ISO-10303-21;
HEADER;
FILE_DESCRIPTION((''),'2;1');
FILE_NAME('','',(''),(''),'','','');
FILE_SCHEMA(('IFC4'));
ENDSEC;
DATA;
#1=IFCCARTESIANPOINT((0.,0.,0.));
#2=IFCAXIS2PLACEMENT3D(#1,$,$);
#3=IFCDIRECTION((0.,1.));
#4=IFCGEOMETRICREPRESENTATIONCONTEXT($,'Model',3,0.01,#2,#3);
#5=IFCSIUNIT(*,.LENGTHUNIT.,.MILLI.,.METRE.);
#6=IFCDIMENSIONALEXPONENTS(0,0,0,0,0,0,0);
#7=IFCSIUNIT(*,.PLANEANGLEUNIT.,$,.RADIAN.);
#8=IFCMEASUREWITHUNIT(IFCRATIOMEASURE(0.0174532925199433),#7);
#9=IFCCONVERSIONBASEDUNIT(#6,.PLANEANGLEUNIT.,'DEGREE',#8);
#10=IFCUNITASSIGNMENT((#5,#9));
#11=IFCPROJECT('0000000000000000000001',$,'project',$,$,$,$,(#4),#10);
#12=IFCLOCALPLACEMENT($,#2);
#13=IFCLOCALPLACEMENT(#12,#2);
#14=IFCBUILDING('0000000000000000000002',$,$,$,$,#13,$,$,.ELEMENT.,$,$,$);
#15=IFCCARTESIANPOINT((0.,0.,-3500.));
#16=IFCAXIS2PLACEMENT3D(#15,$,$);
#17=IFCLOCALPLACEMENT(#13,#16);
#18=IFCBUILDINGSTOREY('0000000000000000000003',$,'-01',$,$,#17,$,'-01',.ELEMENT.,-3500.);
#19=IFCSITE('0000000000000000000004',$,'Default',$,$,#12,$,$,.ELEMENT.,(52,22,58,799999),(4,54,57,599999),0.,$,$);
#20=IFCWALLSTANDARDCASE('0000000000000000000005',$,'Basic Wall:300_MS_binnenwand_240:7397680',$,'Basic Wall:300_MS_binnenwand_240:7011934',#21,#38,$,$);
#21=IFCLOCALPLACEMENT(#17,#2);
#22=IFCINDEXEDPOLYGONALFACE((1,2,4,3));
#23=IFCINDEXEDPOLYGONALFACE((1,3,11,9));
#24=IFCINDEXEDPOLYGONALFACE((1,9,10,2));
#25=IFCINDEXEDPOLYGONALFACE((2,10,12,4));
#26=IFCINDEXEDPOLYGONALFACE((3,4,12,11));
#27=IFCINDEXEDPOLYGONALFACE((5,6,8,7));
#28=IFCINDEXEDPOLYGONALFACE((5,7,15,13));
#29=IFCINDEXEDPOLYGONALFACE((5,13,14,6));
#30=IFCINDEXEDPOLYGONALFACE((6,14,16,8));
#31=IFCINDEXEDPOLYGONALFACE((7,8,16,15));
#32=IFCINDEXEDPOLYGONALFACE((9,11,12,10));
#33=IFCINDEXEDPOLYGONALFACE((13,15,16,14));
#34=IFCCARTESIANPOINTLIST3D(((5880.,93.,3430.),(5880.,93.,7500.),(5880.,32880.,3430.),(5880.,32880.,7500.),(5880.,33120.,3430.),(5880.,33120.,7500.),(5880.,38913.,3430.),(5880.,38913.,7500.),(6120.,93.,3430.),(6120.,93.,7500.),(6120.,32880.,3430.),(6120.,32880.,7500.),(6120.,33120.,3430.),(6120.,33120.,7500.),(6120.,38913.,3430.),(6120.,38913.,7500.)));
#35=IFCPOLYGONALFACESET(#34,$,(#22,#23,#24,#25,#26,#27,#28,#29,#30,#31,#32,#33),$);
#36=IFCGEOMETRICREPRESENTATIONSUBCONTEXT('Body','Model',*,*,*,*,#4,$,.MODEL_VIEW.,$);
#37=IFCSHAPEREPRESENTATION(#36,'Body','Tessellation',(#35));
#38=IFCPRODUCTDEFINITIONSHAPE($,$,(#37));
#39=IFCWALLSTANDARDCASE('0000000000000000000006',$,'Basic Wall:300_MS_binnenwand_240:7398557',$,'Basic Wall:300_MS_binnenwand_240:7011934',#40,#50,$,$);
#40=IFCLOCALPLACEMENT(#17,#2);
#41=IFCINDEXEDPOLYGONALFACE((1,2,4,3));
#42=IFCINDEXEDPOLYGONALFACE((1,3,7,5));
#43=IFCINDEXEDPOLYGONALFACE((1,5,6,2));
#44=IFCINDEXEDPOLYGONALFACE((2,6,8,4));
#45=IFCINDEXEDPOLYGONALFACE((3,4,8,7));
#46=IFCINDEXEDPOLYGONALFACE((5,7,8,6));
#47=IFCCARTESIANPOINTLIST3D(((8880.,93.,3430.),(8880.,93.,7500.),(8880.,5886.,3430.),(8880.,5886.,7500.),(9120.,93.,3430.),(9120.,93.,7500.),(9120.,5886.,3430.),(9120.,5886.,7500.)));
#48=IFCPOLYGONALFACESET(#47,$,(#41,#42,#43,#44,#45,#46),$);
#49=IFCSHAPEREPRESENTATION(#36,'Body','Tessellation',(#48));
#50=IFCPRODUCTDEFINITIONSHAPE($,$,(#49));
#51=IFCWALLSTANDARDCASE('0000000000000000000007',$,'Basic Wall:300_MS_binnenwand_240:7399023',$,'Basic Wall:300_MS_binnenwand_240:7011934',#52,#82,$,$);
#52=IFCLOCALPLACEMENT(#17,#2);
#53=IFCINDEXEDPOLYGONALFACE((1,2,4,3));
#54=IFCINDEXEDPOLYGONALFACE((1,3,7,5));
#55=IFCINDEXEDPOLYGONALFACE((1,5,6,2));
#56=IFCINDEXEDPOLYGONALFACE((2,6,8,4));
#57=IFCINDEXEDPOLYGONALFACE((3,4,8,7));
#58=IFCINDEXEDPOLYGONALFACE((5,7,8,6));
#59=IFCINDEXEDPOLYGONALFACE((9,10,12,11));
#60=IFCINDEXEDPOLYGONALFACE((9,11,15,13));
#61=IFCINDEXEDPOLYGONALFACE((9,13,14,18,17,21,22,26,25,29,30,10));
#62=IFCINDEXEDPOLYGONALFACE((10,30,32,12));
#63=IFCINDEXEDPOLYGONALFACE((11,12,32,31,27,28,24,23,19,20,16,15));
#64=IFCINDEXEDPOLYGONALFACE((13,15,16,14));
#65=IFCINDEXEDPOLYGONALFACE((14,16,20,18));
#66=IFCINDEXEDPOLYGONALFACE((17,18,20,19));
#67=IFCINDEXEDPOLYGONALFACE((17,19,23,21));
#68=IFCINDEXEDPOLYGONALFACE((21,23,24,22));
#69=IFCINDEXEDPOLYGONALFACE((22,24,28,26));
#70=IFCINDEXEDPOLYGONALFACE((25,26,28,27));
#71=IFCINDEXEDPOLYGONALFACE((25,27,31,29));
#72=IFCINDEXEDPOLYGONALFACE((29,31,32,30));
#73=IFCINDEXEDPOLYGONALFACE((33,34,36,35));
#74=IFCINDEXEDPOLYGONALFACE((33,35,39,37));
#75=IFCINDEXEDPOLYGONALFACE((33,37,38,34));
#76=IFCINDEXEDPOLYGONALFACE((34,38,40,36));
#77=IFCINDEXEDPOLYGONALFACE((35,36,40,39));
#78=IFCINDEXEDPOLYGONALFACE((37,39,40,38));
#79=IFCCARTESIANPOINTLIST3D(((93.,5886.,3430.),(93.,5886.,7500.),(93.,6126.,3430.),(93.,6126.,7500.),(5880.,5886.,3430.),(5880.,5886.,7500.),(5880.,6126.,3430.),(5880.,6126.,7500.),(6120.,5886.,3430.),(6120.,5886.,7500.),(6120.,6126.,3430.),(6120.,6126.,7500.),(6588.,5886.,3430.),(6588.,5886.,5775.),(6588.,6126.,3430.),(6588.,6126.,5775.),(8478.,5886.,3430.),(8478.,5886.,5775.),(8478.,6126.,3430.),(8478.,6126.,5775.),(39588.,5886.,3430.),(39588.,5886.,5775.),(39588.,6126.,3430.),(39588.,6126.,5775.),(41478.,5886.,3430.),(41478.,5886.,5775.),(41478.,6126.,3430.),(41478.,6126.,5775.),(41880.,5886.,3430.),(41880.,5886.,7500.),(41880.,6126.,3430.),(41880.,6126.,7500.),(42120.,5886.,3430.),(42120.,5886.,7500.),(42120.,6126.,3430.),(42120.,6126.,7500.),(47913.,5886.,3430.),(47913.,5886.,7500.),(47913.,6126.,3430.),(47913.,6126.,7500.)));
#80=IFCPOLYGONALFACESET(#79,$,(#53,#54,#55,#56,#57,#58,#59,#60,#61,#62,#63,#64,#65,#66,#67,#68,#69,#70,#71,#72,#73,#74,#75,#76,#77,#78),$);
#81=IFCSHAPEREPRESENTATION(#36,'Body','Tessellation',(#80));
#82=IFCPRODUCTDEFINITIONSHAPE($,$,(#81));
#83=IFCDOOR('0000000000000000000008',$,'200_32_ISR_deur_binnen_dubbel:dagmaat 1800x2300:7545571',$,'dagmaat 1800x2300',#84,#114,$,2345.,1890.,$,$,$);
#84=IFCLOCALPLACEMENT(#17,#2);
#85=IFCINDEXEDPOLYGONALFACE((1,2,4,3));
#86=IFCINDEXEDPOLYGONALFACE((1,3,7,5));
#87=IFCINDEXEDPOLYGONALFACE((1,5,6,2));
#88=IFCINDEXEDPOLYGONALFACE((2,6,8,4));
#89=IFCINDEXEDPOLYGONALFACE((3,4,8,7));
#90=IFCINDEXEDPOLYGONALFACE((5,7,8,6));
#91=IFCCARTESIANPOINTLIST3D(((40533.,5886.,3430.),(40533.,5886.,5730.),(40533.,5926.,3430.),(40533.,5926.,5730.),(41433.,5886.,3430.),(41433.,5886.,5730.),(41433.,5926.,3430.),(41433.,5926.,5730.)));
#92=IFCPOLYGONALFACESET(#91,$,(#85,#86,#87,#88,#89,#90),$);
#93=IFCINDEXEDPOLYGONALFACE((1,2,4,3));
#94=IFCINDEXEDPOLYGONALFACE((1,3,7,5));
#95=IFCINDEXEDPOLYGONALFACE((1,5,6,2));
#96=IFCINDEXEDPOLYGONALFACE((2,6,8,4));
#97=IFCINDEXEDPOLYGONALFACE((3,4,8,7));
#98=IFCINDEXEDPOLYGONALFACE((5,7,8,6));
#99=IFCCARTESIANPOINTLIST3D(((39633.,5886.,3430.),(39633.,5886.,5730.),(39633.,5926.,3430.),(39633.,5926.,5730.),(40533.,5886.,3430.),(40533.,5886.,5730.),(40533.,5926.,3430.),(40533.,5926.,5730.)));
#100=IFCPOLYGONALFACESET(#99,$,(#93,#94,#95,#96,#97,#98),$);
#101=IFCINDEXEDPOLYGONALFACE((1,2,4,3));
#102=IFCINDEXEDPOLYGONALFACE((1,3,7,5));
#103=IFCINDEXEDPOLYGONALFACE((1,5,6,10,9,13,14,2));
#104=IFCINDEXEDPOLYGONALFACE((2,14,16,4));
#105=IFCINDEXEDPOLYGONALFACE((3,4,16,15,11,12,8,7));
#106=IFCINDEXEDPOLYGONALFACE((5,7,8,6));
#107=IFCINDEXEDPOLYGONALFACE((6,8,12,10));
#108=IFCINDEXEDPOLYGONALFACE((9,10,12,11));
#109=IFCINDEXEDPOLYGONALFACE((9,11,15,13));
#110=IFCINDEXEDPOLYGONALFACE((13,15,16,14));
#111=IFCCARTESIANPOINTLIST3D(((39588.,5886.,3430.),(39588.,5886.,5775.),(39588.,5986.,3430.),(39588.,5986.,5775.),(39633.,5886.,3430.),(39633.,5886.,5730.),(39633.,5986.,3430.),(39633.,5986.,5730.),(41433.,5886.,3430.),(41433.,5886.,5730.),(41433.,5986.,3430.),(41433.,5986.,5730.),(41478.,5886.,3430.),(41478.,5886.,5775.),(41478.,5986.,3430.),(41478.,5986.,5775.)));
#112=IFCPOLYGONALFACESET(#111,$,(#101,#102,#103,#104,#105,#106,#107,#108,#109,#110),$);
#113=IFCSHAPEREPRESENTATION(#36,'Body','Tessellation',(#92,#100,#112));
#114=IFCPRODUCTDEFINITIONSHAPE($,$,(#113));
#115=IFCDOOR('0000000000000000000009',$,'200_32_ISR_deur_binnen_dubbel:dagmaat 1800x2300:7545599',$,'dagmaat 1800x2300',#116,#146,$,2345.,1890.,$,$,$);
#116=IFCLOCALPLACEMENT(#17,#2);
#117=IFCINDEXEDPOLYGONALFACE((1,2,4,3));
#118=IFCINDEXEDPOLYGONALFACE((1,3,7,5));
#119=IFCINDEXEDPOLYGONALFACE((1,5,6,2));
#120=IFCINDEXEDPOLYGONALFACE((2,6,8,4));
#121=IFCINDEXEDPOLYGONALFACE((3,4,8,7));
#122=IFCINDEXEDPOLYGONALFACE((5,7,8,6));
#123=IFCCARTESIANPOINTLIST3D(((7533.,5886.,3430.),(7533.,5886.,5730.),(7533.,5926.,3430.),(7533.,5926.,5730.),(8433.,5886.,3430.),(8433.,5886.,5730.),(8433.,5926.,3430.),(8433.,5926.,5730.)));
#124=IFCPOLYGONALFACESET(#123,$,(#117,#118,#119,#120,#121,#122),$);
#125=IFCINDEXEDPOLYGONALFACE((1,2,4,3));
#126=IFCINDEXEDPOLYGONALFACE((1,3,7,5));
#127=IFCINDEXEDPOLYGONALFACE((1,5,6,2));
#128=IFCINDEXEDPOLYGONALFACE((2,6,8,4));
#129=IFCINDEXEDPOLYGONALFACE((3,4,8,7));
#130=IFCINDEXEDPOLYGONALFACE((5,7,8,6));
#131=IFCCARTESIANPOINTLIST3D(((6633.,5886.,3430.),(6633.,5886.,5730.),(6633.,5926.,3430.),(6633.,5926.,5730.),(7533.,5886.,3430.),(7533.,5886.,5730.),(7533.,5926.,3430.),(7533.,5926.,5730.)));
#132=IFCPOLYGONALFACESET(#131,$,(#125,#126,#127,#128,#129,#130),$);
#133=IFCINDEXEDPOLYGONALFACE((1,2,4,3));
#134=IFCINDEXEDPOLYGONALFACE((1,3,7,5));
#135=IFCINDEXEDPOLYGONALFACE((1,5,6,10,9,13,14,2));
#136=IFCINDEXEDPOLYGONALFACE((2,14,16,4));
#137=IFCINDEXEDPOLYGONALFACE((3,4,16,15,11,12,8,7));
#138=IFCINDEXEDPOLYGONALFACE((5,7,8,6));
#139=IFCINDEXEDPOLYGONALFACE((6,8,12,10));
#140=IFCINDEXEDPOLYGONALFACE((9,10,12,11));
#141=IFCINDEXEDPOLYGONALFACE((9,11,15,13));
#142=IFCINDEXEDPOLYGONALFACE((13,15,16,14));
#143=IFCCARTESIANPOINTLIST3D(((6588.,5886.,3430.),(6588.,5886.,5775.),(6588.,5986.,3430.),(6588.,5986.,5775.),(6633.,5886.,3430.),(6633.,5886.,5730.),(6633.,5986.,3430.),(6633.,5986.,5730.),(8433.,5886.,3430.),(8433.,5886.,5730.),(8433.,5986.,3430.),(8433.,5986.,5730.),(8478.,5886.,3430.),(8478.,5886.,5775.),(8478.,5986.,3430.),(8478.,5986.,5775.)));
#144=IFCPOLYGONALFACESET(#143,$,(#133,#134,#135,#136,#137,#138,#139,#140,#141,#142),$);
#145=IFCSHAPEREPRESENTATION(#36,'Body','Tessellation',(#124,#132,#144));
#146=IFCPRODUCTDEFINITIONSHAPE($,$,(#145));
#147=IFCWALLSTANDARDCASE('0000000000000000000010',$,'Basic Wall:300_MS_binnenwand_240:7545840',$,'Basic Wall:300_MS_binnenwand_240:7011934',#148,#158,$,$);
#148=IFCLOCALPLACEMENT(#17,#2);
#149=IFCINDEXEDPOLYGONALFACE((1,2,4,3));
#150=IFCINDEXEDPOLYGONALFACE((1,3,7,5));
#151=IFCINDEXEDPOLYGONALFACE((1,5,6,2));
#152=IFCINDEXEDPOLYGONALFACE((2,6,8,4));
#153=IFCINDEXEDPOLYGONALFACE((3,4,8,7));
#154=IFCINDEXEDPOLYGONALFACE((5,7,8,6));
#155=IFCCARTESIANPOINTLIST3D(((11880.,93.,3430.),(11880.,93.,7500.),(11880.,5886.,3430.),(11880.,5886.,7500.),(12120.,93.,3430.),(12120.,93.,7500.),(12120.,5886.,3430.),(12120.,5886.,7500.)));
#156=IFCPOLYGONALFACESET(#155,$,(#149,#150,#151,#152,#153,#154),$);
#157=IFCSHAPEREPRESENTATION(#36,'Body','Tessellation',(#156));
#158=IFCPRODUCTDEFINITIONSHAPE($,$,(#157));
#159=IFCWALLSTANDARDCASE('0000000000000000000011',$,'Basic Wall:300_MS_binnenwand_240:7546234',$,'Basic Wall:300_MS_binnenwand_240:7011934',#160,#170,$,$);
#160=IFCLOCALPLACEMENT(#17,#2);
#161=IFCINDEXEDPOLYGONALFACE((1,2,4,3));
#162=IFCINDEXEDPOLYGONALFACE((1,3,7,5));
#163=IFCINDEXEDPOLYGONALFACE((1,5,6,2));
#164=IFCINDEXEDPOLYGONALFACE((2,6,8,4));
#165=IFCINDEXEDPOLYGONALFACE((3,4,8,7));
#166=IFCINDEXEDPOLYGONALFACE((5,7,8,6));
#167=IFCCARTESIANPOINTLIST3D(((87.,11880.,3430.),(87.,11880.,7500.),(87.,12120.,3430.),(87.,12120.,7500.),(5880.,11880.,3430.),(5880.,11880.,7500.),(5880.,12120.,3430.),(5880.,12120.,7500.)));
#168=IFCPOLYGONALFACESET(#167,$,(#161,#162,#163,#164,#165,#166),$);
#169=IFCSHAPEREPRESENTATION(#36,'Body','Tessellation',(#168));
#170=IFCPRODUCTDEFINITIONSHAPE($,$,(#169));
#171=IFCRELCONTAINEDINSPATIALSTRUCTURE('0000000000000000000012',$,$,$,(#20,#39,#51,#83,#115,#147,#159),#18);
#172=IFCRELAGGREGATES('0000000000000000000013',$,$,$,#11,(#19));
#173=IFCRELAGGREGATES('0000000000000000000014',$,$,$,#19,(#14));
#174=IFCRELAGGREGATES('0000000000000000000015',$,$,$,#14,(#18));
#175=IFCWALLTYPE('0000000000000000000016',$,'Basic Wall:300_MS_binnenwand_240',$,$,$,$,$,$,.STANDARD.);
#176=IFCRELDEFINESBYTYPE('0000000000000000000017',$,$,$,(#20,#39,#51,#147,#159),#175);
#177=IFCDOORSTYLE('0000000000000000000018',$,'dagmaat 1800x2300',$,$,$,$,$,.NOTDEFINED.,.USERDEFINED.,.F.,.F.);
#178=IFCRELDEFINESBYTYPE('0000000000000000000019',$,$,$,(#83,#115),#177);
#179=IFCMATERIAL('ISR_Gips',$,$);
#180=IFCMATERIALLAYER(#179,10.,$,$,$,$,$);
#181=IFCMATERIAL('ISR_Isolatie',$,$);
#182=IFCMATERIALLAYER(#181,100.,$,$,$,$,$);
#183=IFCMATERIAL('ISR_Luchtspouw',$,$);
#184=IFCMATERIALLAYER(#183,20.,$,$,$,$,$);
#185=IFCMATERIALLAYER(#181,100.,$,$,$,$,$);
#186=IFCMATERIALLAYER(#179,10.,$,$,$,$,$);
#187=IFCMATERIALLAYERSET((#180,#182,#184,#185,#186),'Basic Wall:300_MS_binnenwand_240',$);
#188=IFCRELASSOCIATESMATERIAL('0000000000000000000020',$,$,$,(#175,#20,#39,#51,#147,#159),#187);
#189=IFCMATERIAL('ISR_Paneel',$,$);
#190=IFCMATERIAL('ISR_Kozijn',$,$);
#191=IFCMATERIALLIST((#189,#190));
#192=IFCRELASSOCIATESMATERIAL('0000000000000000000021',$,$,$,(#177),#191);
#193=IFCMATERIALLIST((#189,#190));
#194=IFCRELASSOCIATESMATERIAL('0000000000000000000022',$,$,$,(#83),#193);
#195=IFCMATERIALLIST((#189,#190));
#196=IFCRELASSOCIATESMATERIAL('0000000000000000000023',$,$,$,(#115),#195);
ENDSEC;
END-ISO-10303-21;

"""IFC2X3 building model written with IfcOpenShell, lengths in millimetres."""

from ifc_helpers import new_model, entity, si_unit, converted_unit, direction, frame, frame_2d, origin, origin_2d_with_axis, place, context, subcontext, project, spatial, polyline, rectangle, outline, extrude, source, transform, mapped, material, material_list, layer, layer_set, layer_usage, type_object, type_shapes, element, fill, save


model = new_model("IFC2X3")

# Units and contexts
model_context = context("Model", 3, precision=0.01, world=origin(), true_north=direction((0.0, 1.0)))
body_context = subcontext(model_context, "Body", "Model", "MODEL_VIEW")
ifc_project = project(units=[si_unit("LENGTHUNIT", "METRE", prefix="MILLI"), converted_unit("PLANEANGLEUNIT", "DEGREE", entity("IfcRatioMeasure", 0.0174532925199433), si_unit("PLANEANGLEUNIT", "RADIAN"), dimensions=[0, 0, 0, 0, 0, 0, 0])], contexts=[model_context])

# Site, building, storey
site_placement = place(None, origin())
site = spatial("IfcSite", under=ifc_project, at=site_placement, Name="Default", CompositionType="ELEMENT", RefLatitude=(52, 22, 58, 799999), RefLongitude=(4, 54, 57, 599999), RefElevation=0.0)
building_placement = place(site_placement, origin())
building = spatial("IfcBuilding", under=site, at=building_placement, CompositionType="ELEMENT")
storey_placement = place(building_placement, frame((0.0, 0.0, -3500.0)))
storey = spatial("IfcBuildingStorey", under=building, at=storey_placement, Name="-01", LongName="-01", CompositionType="ELEMENT", Elevation=-3500.0)

# Shared definitions
ifc_material_1 = material(Name="ISR_Kozijn")

# Wall, opening
ifc_material_2 = material(Name="ISR_Gips")
ifc_layer_1 = layer(ifc_material_2, 10.0)
ifc_material_3 = material(Name="ISR_Isolatie")
ifc_layer_2 = layer(ifc_material_3, 100.0)
ifc_material_4 = material(Name="ISR_Luchtspouw")
ifc_layer_3 = layer(ifc_material_4, 20.0)
ifc_layer_4 = layer(ifc_material_3, 100.0)
ifc_layer_5 = layer(ifc_material_2, 10.0)
ifc_layer_set_1 = layer_set([ifc_layer_1, ifc_layer_2, ifc_layer_3, ifc_layer_4, ifc_layer_5], Name="Basic Wall:300_MS_binnenwand_240")
ifc_layer_usage_1 = layer_usage(ifc_layer_set_1, "AXIS2", "NEGATIVE", 120.0)
wall_type_1 = type_object("IfcWallType", Name="Basic Wall:300_MS_binnenwand_240", PredefinedType="STANDARD", material=ifc_layer_set_1)
wall_1_placement = place(storey_placement, frame((6000.0, 93.0, 3430.0), z_axis=(0.0, 0.0, 1.0), x_axis=(0.0, 1.0, 0.0)))
wall_1 = element("IfcWallStandardCase", 1, at=wall_1_placement, inside=storey, type_object=wall_type_1, material=ifc_layer_usage_1, Name="Basic Wall:300_MS_binnenwand_240:7397680", ObjectType="Basic Wall:300_MS_binnenwand_240:7011934", context=body_context, shape_type="SweptSolid", body=[
    extrude(rectangle(XDim=38820.0, YDim=240.0, at=frame_2d((19410.0, 0.0), x_axis=(-1.0, 0.0))), origin(), (0.0, 0.0, 1.0), 4070.0),
])
opening_1_placement = place(storey_placement, frame((6000.0, 93.0, 3430.0), z_axis=(0.0, 0.0, 1.0), x_axis=(0.0, 1.0, 0.0)))
element("IfcOpeningElement", 2, at=opening_1_placement, cuts=wall_1, ObjectType="Opening", context=body_context, shape_type="SweptSolid", body=[
    extrude(rectangle(XDim=4070.0, YDim=240.0, at=frame_2d((0.0, 0.0), x_axis=(1.0, 0.0))), frame((32787.0, 0.0, 2035.0), z_axis=(1.0, 0.0, 0.0), x_axis=(0.0, 0.0, -1.0)), (0.0, 0.0, 1.0), 240.0),
])

# Wall
ifc_layer_usage_2 = layer_usage(ifc_layer_set_1, "AXIS2", "POSITIVE", -120.0)
wall_2_placement = place(storey_placement, frame((9000.0, 5886.0, 3430.0), z_axis=(0.0, 0.0, 1.0), x_axis=(0.0, -1.0, 0.0)))
element("IfcWallStandardCase", 3, at=wall_2_placement, inside=storey, type_object=wall_type_1, material=ifc_layer_usage_2, Name="Basic Wall:300_MS_binnenwand_240:7398557", ObjectType="Basic Wall:300_MS_binnenwand_240:7011934", context=body_context, shape_type="SweptSolid", body=[
    extrude(rectangle(XDim=5793.0, YDim=240.0, at=frame_2d((2896.5, 0.0), x_axis=(-1.0, 0.0))), origin(), (0.0, 0.0, 1.0), 4070.0),
])

# Wall, openings, doors
ifc_layer_usage_3 = layer_usage(ifc_layer_set_1, "AXIS2", "POSITIVE", -120.0)
wall_3_placement = place(storey_placement, frame((93.0, 6006.0, 3430.0)))
wall_3 = element("IfcWallStandardCase", 4, at=wall_3_placement, inside=storey, type_object=wall_type_1, material=ifc_layer_usage_3, Name="Basic Wall:300_MS_binnenwand_240:7399023", ObjectType="Basic Wall:300_MS_binnenwand_240:7011934", context=body_context, shape_type="SweptSolid", body=[
    extrude(rectangle(XDim=47820.0, YDim=240.0, at=frame_2d((23910.0, 0.0), x_axis=(-1.0, 0.0))), origin(), (0.0, 0.0, 1.0), 4070.0),
])
opening_2_placement = place(storey_placement, frame((93.0, 6006.0, 3430.0)))
element("IfcOpeningElement", 5, at=opening_2_placement, cuts=wall_3, ObjectType="Opening", context=body_context, shape_type="SweptSolid", body=[
    extrude(rectangle(XDim=4070.0, YDim=240.0, at=origin_2d_with_axis()), frame((41787.0, 0.0, 2035.0), z_axis=(1.0, 0.0, 0.0), x_axis=(0.0, 0.0, -1.0)), (0.0, 0.0, 1.0), 240.0),
])
opening_3_placement = place(storey_placement, frame((93.0, 6006.0, 3430.0)))
element("IfcOpeningElement", 6, at=opening_3_placement, cuts=wall_3, ObjectType="Opening", context=body_context, shape_type="SweptSolid", body=[
    extrude(rectangle(XDim=4070.0, YDim=240.0, at=frame_2d((0.0, 0.0), x_axis=(1.0, 0.0))), frame((5787.0, 0.0, 2035.0), z_axis=(1.0, 0.0, 0.0), x_axis=(0.0, 0.0, -1.0)), (0.0, 0.0, 1.0), 240.0),
])
opening_4_placement = place(wall_3_placement, frame((41385.0, 120.0, 0.0)))
opening_4 = element("IfcOpeningElement", 7, at=opening_4_placement, cuts=wall_3, ObjectType="Opening", context=body_context, shape_type="SweptSolid", body=[
    extrude(rectangle(XDim=2345.0, YDim=1890.0, at=frame_2d((1172.5, 945.0), x_axis=(-1.0, 0.0))), frame((0.0, 0.0, 0.0), z_axis=(0.0, -1.0, 0.0), x_axis=(0.0, 0.0, 1.0)), (0.0, 0.0, 1.0), 240.0),
])
opening_5_placement = place(wall_3_placement, frame((8385.0, 120.0, 0.0)))
opening_5 = element("IfcOpeningElement", 8, at=opening_5_placement, cuts=wall_3, ObjectType="Opening", context=body_context, shape_type="SweptSolid", body=[
    extrude(rectangle(XDim=2345.0, YDim=1890.0, at=frame_2d((1172.5, 945.0), x_axis=(-1.0, 0.0))), frame((0.0, 0.0, 0.0), z_axis=(0.0, -1.0, 0.0), x_axis=(0.0, 0.0, 1.0)), (0.0, 0.0, 1.0), 240.0),
])
ifc_material_5 = material(Name="ISR_Paneel")
ifc_material_list_1 = material_list([ifc_material_5, ifc_material_1])
ifc_material_list_2 = material_list([ifc_material_5, ifc_material_1])
door_style = type_object("IfcDoorStyle", Name="dagmaat 1800x2300", ConstructionType="USERDEFINED", OperationType="NOTDEFINED", ParameterTakesPrecedence=False, Sizeable=False, material=ifc_material_list_2)
shared_shape_1 = source(origin(), body_context, "Body", "SweptSolid", [
    extrude(rectangle(XDim=40.0, YDim=900.0, at=origin_2d_with_axis()), frame((495.0, 220.0, 0.0), z_axis=(0.0, 0.0, 1.0), x_axis=(0.0, -1.0, 0.0)), (0.0, 0.0, 1.0), 2300.0),
    extrude(rectangle(XDim=40.0, YDim=900.0, at=frame_2d((0.0, 0.0), x_axis=(1.0, 0.0))), frame((1395.0, 220.0, 0.0), z_axis=(0.0, 0.0, 1.0), x_axis=(0.0, 1.0, 0.0)), (0.0, 0.0, 1.0), 2300.0),
    extrude(outline(polyline([(-1161.2, -900.0), (-1161.2, -945.0), (1183.7, -945.0), (1183.7, 945.0), (-1161.2, 945.0), (-1161.2, 900.0), (1138.8, 900.0), (1138.8, -900.0), (-1161.2, -900.0)])), frame((945.0, 240.0, 1161.2), z_axis=(0.0, 1.0, 0.0), x_axis=(0.0, 0.0, 1.0)), (0.0, 0.0, -1.0), 100.0),
])
type_shapes(door_style, [shared_shape_1])
door_1_placement = place(opening_4_placement, frame((0.0, 0.0, 0.0), z_axis=(0.0, 0.0, 1.0), x_axis=(-1.0, 0.0, 0.0)))
door_1 = element("IfcDoor", 9, at=door_1_placement, inside=storey, type_object=door_style, material=ifc_material_list_1, Name="200_32_ISR_deur_binnen_dubbel:dagmaat 1800x2300:7545571", ObjectType="dagmaat 1800x2300", OverallHeight=2345.0, OverallWidth=1890.0, context=body_context, shape_type="MappedRepresentation", body=[
    mapped(shared_shape_1, transform((0.0, 0.0, 0.0), scale=1.0)),
])
fill(opening_4, door_1)
ifc_material_list_3 = material_list([ifc_material_5, ifc_material_1])
door_2_placement = place(opening_5_placement, frame((0.0, 0.0, 0.0), z_axis=(0.0, 0.0, 1.0), x_axis=(-1.0, 0.0, 0.0)))
door_2 = element("IfcDoor", 10, at=door_2_placement, inside=storey, type_object=door_style, material=ifc_material_list_3, Name="200_32_ISR_deur_binnen_dubbel:dagmaat 1800x2300:7545599", ObjectType="dagmaat 1800x2300", OverallHeight=2345.0, OverallWidth=1890.0, context=body_context, shape_type="MappedRepresentation", body=[
    mapped(shared_shape_1, transform((0.0, 0.0, 0.0), scale=1.0)),
])
fill(opening_5, door_2)

# Walls
ifc_layer_usage_4 = layer_usage(ifc_layer_set_1, "AXIS2", "POSITIVE", -120.0)
wall_4_placement = place(storey_placement, frame((12000.0, 5886.0, 3430.0), z_axis=(0.0, 0.0, 1.0), x_axis=(0.0, -1.0, 0.0)))
element("IfcWallStandardCase", 11, at=wall_4_placement, inside=storey, type_object=wall_type_1, material=ifc_layer_usage_4, Name="Basic Wall:300_MS_binnenwand_240:7545840", ObjectType="Basic Wall:300_MS_binnenwand_240:7011934", context=body_context, shape_type="SweptSolid", body=[
    extrude(rectangle(XDim=5793.0, YDim=240.0, at=frame_2d((2896.5, 0.0), x_axis=(-1.0, 0.0))), origin(), (0.0, 0.0, 1.0), 4070.0),
])
ifc_layer_usage_5 = layer_usage(ifc_layer_set_1, "AXIS2", "NEGATIVE", 120.0)
wall_5_placement = place(storey_placement, frame((87.0, 12000.0, 3430.0)))
element("IfcWallStandardCase", 12, at=wall_5_placement, inside=storey, type_object=wall_type_1, material=ifc_layer_usage_5, Name="Basic Wall:300_MS_binnenwand_240:7546234", ObjectType="Basic Wall:300_MS_binnenwand_240:7011934", context=body_context, shape_type="SweptSolid", body=[
    extrude(rectangle(XDim=5793.0, YDim=240.0, at=frame_2d((2896.5, 0.0), x_axis=(-1.0, 0.0))), origin(), (0.0, 0.0, 1.0), 4070.0),
])

save(model, "model.ifc")
